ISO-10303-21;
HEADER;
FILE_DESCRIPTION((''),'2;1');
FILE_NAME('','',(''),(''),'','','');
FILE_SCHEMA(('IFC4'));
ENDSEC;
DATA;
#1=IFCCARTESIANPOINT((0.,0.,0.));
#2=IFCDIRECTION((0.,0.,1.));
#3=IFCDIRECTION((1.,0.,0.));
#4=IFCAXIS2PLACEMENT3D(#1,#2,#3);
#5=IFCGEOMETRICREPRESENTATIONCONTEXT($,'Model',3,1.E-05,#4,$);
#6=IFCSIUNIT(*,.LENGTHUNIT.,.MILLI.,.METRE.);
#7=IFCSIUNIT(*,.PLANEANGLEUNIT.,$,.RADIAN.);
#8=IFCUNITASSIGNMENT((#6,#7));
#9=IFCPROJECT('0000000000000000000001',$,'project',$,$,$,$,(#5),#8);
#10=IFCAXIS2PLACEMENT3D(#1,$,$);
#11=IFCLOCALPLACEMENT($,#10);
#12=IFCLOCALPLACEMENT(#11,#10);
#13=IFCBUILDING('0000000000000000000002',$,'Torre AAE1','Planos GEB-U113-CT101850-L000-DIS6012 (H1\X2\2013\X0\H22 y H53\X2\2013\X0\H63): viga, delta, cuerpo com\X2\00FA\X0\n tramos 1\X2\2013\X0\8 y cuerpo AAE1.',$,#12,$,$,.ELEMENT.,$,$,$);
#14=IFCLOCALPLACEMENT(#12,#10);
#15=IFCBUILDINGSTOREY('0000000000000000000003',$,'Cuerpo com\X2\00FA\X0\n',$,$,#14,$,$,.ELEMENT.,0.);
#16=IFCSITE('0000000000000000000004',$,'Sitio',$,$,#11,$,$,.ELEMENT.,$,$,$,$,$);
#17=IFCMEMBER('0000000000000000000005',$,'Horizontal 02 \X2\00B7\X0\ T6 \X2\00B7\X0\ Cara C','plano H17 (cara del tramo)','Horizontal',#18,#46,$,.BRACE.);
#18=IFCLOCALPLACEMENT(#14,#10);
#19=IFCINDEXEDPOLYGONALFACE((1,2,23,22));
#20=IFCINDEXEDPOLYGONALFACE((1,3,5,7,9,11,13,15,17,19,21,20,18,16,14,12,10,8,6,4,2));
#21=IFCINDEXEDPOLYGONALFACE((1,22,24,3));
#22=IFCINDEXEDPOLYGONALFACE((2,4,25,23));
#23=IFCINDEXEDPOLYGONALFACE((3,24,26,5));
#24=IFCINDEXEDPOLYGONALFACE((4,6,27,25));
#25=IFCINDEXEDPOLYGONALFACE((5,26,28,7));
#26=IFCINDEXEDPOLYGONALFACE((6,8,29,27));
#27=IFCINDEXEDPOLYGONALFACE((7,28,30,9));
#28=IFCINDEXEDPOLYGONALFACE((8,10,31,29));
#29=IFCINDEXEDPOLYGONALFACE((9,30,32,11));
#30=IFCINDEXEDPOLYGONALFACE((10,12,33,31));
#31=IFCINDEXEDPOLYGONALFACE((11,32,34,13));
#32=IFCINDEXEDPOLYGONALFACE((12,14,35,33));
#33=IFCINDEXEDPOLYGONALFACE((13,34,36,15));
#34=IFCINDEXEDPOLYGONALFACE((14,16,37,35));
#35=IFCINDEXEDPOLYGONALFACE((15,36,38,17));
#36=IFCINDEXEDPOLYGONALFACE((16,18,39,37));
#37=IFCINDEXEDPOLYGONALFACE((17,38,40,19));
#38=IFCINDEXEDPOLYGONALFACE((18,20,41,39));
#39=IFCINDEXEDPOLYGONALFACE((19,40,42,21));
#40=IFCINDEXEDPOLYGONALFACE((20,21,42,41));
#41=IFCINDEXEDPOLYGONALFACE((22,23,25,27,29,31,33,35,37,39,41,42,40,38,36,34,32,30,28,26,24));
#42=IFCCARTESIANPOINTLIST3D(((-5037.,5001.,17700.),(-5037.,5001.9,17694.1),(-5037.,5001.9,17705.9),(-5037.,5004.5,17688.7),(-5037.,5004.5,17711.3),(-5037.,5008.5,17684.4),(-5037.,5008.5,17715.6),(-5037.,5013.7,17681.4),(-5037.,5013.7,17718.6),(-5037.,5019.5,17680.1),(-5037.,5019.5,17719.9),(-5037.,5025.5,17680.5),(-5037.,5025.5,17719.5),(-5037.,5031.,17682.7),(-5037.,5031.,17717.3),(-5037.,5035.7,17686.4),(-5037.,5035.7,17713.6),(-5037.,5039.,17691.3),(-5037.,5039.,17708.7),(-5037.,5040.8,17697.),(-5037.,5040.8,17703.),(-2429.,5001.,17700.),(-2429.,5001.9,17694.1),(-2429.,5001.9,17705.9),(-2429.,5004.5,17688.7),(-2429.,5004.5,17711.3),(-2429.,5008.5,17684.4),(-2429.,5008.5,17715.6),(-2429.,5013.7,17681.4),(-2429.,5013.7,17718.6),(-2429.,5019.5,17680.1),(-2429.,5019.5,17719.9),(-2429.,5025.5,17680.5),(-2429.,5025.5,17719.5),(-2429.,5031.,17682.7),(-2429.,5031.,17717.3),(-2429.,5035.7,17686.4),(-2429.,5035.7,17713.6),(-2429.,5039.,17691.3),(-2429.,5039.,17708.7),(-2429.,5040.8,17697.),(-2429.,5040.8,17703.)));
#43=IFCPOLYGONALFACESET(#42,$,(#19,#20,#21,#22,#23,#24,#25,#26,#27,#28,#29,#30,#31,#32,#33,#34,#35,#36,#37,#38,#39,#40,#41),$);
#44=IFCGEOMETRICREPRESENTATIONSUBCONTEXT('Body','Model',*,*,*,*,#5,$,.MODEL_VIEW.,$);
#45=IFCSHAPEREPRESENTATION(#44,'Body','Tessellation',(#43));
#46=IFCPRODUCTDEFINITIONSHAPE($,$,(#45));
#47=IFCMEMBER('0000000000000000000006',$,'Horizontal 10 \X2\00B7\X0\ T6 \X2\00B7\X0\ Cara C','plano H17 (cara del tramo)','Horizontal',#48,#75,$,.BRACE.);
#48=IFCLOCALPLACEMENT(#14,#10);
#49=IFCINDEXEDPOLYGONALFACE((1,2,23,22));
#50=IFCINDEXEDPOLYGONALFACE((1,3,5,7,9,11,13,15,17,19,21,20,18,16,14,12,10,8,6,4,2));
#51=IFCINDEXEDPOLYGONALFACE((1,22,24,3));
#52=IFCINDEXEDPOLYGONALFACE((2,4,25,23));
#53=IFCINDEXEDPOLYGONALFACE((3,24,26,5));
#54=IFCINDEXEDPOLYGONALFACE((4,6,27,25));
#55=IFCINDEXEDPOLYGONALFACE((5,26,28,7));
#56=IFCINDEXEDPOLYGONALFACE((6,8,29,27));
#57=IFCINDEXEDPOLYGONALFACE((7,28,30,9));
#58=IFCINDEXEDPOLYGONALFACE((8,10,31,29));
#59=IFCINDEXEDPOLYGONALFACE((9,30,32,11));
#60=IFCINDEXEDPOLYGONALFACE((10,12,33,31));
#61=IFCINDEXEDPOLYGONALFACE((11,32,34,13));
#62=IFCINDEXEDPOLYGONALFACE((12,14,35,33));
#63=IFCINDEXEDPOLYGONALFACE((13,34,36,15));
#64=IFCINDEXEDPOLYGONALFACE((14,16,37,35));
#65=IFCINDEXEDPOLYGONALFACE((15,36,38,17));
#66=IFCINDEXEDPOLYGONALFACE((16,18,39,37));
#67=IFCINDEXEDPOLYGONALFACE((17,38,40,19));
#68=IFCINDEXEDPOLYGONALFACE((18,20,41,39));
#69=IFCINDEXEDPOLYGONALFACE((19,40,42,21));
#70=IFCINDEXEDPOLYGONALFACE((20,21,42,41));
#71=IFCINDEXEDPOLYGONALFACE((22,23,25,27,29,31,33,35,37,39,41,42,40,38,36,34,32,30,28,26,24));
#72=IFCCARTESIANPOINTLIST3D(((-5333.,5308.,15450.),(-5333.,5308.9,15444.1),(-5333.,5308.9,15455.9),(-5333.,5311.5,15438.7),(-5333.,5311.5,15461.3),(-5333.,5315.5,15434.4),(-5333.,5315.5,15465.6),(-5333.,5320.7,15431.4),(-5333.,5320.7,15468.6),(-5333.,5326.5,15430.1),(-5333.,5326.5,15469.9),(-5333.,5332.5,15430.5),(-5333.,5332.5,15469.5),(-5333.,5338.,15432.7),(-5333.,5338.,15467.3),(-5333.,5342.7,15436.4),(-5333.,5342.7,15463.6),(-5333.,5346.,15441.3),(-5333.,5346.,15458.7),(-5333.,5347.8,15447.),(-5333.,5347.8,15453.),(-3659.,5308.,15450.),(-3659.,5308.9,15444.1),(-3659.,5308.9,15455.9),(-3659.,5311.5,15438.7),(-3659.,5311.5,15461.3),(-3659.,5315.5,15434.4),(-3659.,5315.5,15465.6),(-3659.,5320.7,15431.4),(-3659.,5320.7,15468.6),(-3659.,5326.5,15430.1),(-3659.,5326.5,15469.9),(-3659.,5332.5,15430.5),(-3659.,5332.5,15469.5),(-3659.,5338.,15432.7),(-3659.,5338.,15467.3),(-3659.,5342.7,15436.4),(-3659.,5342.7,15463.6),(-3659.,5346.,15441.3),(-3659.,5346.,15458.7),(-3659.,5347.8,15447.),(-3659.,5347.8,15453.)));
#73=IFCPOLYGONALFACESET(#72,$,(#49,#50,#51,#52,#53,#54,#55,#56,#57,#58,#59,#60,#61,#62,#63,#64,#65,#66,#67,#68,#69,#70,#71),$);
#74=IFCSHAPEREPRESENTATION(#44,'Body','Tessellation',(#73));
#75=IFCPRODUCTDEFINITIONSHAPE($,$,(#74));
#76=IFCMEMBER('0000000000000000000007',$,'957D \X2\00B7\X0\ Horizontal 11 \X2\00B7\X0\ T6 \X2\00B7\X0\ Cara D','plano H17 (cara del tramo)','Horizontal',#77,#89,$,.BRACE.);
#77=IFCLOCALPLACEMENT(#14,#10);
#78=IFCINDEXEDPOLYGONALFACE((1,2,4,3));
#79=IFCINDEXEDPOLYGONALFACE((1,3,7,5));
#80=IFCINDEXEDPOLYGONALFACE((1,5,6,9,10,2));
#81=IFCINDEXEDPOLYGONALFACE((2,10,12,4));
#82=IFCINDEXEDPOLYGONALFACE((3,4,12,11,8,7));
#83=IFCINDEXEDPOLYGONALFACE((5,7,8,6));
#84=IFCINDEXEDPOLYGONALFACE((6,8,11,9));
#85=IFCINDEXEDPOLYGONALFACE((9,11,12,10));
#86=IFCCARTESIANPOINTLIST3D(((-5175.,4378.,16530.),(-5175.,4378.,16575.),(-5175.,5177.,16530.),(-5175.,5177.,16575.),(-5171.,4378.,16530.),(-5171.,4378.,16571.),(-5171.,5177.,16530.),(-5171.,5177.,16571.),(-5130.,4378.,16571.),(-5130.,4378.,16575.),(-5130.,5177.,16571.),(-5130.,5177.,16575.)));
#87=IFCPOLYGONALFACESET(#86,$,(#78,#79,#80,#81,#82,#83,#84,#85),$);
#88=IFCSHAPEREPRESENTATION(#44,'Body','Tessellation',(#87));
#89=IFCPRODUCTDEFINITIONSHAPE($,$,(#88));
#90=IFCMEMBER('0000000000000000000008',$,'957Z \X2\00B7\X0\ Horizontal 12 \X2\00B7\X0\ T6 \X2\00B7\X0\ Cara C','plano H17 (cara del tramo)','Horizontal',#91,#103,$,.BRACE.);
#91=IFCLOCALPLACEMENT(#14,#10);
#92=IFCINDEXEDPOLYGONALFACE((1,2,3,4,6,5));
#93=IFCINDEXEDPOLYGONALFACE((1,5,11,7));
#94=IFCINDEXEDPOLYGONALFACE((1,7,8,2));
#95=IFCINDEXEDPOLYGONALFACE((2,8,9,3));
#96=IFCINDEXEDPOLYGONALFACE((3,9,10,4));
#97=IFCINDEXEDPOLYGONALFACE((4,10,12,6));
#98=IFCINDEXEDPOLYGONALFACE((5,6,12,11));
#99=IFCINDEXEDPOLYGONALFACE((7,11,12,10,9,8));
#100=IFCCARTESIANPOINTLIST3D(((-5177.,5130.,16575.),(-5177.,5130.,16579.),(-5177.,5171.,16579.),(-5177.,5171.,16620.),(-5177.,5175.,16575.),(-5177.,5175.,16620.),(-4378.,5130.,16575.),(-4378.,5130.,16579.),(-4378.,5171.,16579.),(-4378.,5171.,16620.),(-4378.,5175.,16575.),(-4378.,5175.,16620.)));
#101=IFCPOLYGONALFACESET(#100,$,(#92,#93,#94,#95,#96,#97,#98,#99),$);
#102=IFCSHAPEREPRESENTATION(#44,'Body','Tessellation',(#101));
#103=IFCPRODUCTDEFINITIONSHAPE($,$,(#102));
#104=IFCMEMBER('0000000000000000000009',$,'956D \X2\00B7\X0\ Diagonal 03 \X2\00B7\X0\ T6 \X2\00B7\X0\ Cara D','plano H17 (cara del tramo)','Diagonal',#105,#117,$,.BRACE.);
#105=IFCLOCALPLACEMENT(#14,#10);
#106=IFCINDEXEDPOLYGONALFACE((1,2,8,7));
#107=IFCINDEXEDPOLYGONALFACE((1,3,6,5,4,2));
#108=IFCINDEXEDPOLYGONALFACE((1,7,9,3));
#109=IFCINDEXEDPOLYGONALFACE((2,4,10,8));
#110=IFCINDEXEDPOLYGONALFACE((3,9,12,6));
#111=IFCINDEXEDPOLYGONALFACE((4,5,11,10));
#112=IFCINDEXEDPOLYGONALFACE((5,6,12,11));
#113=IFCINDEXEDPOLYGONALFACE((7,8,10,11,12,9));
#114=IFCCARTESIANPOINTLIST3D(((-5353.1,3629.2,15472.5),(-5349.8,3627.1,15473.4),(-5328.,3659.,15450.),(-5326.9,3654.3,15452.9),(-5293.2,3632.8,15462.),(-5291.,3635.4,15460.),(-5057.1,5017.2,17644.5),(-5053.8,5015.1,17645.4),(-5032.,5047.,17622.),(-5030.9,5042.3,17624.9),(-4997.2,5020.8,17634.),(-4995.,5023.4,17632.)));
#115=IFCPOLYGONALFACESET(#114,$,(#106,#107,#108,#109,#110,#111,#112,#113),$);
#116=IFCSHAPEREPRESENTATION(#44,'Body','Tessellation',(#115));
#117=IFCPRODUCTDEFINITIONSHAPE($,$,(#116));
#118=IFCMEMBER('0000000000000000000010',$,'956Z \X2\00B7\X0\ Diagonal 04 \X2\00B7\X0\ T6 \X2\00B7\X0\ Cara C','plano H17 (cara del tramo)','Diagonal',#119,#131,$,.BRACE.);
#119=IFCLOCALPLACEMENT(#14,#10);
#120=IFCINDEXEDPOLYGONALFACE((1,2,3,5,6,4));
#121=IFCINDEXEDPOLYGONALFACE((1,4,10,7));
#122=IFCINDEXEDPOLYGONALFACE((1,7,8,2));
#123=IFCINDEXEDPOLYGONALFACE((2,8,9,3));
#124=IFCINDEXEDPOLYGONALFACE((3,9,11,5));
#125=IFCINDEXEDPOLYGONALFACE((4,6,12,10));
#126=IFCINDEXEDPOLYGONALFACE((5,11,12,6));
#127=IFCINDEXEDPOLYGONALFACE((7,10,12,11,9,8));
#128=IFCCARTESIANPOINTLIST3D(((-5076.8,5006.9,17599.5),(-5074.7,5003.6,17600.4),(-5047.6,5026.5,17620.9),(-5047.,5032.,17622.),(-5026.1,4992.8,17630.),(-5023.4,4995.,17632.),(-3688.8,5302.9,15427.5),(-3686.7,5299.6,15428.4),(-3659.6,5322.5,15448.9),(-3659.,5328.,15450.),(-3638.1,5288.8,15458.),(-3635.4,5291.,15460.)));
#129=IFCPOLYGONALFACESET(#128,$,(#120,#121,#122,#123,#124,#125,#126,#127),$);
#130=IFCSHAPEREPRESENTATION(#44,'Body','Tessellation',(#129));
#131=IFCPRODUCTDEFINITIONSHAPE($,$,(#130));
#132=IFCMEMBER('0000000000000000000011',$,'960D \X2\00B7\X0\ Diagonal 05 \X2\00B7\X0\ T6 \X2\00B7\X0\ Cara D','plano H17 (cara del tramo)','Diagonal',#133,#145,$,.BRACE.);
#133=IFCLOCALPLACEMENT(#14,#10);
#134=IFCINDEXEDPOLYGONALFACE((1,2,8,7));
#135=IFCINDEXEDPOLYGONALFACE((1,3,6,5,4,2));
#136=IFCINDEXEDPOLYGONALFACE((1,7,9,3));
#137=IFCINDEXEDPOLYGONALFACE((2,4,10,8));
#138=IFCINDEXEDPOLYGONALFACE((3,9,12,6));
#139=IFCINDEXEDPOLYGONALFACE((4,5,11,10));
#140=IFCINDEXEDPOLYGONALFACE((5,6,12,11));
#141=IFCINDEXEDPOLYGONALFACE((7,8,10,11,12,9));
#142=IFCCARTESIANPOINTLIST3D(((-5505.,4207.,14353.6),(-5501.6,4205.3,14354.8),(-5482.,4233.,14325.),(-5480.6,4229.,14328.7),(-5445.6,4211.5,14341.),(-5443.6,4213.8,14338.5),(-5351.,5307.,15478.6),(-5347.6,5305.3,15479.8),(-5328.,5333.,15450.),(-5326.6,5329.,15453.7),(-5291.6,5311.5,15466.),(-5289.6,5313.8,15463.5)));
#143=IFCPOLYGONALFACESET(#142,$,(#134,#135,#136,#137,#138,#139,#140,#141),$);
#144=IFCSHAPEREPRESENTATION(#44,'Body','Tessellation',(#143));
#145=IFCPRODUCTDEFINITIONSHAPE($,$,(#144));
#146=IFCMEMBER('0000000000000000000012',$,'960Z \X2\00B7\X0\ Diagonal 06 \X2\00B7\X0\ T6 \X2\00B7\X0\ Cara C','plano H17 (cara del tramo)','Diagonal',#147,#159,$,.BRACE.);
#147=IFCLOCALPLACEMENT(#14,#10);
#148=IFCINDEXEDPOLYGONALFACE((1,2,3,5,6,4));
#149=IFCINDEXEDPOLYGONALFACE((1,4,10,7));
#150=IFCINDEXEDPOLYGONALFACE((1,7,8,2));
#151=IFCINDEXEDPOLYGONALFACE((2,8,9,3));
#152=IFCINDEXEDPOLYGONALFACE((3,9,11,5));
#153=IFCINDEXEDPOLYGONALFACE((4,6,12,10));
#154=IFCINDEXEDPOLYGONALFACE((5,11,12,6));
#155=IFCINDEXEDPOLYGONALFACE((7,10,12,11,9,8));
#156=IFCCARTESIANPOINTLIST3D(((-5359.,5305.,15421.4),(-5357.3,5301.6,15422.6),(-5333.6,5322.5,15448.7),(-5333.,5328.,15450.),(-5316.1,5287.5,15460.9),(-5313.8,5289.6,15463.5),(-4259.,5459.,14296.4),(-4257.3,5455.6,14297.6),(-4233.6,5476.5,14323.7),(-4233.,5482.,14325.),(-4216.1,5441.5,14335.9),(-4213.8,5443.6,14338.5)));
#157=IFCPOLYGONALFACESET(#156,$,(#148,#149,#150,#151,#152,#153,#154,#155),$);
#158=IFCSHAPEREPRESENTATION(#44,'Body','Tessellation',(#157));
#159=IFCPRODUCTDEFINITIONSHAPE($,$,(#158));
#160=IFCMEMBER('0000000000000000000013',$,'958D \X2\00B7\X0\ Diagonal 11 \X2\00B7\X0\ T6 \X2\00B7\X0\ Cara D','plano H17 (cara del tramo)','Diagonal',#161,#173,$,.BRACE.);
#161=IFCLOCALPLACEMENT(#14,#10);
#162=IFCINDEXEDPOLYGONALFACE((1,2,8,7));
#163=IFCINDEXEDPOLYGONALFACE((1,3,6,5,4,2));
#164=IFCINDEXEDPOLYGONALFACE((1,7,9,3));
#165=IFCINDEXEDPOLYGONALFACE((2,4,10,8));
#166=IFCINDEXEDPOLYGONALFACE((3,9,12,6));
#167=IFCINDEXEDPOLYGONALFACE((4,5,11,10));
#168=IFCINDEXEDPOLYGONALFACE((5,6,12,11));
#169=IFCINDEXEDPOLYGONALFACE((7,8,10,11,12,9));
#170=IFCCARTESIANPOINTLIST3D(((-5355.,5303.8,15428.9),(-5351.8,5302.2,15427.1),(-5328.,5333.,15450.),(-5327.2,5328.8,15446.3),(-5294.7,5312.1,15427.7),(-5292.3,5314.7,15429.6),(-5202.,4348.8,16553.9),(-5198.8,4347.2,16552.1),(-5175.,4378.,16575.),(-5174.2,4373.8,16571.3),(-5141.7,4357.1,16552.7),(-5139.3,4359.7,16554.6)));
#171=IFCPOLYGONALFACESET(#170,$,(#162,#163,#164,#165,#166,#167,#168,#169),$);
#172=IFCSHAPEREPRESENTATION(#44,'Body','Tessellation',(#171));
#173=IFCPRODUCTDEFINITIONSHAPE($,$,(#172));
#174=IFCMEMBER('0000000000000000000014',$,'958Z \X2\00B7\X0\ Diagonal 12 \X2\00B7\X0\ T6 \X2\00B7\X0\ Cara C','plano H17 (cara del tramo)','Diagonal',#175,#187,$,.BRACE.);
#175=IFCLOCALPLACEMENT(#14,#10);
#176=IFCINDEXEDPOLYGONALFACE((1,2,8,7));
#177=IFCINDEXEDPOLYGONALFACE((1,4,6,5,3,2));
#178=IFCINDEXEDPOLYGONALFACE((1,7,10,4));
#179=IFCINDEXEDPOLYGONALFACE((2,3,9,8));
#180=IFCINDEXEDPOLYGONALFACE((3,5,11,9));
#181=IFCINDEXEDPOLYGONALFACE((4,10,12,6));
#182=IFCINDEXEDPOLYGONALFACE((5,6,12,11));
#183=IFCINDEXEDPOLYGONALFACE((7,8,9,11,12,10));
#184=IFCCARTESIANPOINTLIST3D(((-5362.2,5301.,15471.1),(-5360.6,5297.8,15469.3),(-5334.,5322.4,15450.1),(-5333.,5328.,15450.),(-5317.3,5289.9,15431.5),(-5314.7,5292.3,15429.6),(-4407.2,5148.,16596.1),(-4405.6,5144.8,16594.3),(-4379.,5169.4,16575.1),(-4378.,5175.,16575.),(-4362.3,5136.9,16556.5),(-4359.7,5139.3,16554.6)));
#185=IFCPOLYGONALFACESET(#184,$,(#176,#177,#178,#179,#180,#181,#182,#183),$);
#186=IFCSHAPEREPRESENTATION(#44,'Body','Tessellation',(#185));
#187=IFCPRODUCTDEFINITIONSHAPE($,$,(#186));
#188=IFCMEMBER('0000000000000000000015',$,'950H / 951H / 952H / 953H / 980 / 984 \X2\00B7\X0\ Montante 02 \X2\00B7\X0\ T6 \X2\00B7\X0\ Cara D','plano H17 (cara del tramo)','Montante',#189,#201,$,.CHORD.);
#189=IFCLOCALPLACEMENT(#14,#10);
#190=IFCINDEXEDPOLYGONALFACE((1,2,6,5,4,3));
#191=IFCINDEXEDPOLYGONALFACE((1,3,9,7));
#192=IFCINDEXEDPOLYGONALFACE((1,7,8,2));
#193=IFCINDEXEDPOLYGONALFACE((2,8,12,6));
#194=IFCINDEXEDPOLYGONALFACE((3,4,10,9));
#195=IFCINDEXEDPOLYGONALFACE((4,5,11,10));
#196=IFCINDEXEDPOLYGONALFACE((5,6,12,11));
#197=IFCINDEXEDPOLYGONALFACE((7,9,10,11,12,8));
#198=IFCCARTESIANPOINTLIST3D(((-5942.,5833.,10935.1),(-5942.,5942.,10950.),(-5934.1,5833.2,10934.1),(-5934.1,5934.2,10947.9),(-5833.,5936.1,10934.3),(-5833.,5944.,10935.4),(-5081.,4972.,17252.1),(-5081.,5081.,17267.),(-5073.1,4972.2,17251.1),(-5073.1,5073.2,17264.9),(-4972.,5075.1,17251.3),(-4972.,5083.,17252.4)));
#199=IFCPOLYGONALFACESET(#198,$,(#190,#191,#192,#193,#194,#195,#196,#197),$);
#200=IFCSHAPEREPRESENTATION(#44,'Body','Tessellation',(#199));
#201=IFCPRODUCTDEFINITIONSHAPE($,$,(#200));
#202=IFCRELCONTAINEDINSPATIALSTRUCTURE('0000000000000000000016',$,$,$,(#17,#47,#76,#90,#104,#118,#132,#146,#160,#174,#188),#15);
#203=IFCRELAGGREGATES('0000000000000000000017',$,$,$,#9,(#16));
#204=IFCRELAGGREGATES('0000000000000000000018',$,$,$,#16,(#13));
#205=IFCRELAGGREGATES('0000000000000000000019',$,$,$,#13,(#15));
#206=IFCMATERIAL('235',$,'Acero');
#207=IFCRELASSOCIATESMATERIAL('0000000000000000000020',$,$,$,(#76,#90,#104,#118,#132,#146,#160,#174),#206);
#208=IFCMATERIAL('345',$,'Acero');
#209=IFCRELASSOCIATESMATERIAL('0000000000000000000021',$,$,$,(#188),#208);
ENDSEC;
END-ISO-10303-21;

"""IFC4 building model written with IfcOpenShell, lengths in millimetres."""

from ifc_helpers import new_model, si_unit, frame, frame_2d, origin, origin_with_axes, place, context, subcontext, project, spatial, circle, l_section, extrude, material, element, save


model = new_model("IFC4")

# Units and contexts
model_context = context("Model", 3, precision=1e-05, world=origin_with_axes())
body_context = subcontext(model_context, "Body", "Model", "MODEL_VIEW")
ifc_project = project(units=[si_unit("LENGTHUNIT", "METRE", prefix="MILLI"), si_unit("PLANEANGLEUNIT", "RADIAN")], contexts=[model_context])

# Site, building, storey
site_placement = place(None, origin())
site = spatial("IfcSite", under=ifc_project, at=site_placement, Name="Sitio", CompositionType="ELEMENT")
building_placement = place(site_placement, origin())
building = spatial("IfcBuilding", under=site, at=building_placement, Name="Torre AAE1", Description="Planos GEB-U113-CT101850-L000-DIS6012 (H1–H22 y H53–H63): viga, delta, cuerpo común tramos 1–8 y cuerpo AAE1.", CompositionType="ELEMENT")
storey_placement = place(building_placement, origin())
storey = spatial("IfcBuildingStorey", under=building, at=storey_placement, Name="Cuerpo común", CompositionType="ELEMENT", Elevation=0.0)

# Members
for number, where, z_axis, x_axis, name in (
    (1, (-5037.0, 5021.0, 17700.0), (1.0, 0.0, 0.0), (0.0, -1.0, 0.0), "Horizontal 02 · T6 · Cara C"),
):
    element("IfcMember", number, at=place(storey_placement, frame(where, z_axis=z_axis, x_axis=x_axis)), inside=storey, Name=name, Description="plano H17 (cara del tramo)", ObjectType="Horizontal", PredefinedType="BRACE", context=body_context, shape_type="SweptSolid", body=[
        extrude(circle(Radius=20.0), None, (0.0, 0.0, 1.0), 2608.0),
    ])
member_1_placement = place(storey_placement, frame((-3659.0, 5328.0, 15450.0), z_axis=(-1.0, 0.0, 0.0), x_axis=(0.0, -1.0, 0.0)))
element("IfcMember", 2, at=member_1_placement, inside=storey, Name="Horizontal 10 · T6 · Cara C", Description="plano H17 (cara del tramo)", ObjectType="Horizontal", PredefinedType="BRACE", context=body_context, shape_type="SweptSolid", body=[
    extrude(circle(Radius=20.0), None, (0.0, 0.0, 1.0), 1674.0),
])
ifc_material_1 = material(Name="235", Category="Acero")
for number, where, z_axis, x_axis, name in (
    (3, (-5175.0, 4378.0, 16575.0), (0.0, 1.0, 0.0), (1.0, 0.0, 0.0), "957D · Horizontal 11 · T6 · Cara D"),
    (4, (-4378.0, 5175.0, 16575.0), (-1.0, 0.0, 0.0), (0.0, -1.0, 0.0), "957Z · Horizontal 12 · T6 · Cara C"),
):
    element("IfcMember", number, at=place(storey_placement, frame(where, z_axis=z_axis, x_axis=x_axis)), inside=storey, material=ifc_material_1, Name=name, Description="plano H17 (cara del tramo)", ObjectType="Horizontal", PredefinedType="BRACE", context=body_context, shape_type="SweptSolid", body=[
        extrude(l_section(Depth=45.0, Width=45.0, Thickness=4.0, at=frame_2d((22.5, 22.5))), None, (0.0, 0.0, 1.0), 799.0),
    ])
for number, where, z_axis, x_axis, name in (
    (5, (-5032.0, 5047.0, 17622.0), (-0.114085, -0.534965, -0.837136), (0.822462, -0.523514, 0.222463), "956D · Diagonal 03 · T6 · Cara D"),
    (6, (-5047.0, 5032.0, 17622.0), (0.534965, 0.114085, -0.837136), (0.523514, -0.822462, 0.222463), "956Z · Diagonal 04 · T6 · Cara C"),
):
    element("IfcMember", number, at=place(storey_placement, frame(where, z_axis=z_axis, x_axis=x_axis)), inside=storey, material=ifc_material_1, Name=name, Description="plano H17 (cara del tramo)", ObjectType="Diagonal", PredefinedType="BRACE", context=body_context, shape_type="SweptSolid", body=[
        extrude(l_section(Depth=45.0, Width=45.0, Thickness=4.0, at=frame_2d((22.5, 22.5))), None, (0.0, 0.0, 1.0), 2594.6),
    ])
for number, where, z_axis, x_axis, name in (
    (7, (-5328.0, 5333.0, 15450.0), (-0.097411, -0.695793, -0.711606), (0.853622, -0.426031, 0.299712), "960D · Diagonal 05 · T6 · Cara D"),
    (8, (-5333.0, 5328.0, 15450.0), (0.695793, 0.097411, -0.711606), (0.426031, -0.853622, 0.299712), "960Z · Diagonal 06 · T6 · Cara C"),
):
    element("IfcMember", number, at=place(storey_placement, frame(where, z_axis=z_axis, x_axis=x_axis)), inside=storey, material=ifc_material_1, Name=name, Description="plano H17 (cara del tramo)", ObjectType="Diagonal", PredefinedType="BRACE", context=body_context, shape_type="SweptSolid", body=[
        extrude(l_section(Depth=45.0, Width=45.0, Thickness=4.0, at=frame_2d((22.5, 22.5))), None, (0.0, 0.0, 1.0), 1580.9),
    ])
for number, where, z_axis, x_axis, name in (
    (9, (-5175.0, 4378.0, 16575.0), (-0.103128, 0.643706, -0.758292), (0.793627, -0.40631, -0.452845), "958D · Diagonal 11 · T6 · Cara D"),
    (10, (-4378.0, 5175.0, 16575.0), (-0.643706, 0.103128, -0.758292), (0.40631, -0.793627, -0.452845), "958Z · Diagonal 12 · T6 · Cara C"),
):
    element("IfcMember", number, at=place(storey_placement, frame(where, z_axis=z_axis, x_axis=x_axis)), inside=storey, material=ifc_material_1, Name=name, Description="plano H17 (cara del tramo)", ObjectType="Diagonal", PredefinedType="BRACE", context=body_context, shape_type="SweptSolid", body=[
        extrude(l_section(Depth=45.0, Width=45.0, Thickness=4.0, at=frame_2d((22.5, 22.5))), None, (0.0, 0.0, 1.0), 1483.6),
    ])
ifc_material_2 = material(Name="345", Category="Acero")
member_2_placement = place(storey_placement, frame((-5081.0, 5081.0, 17267.0), z_axis=(-0.133835, 0.133835, -0.981925), x_axis=(0.991004, 0.018074, -0.132609)))
element("IfcMember", 11, at=member_2_placement, inside=storey, material=ifc_material_2, Name="950H / 951H / 952H / 953H / 980 / 984 · Montante 02 · T6 · Cara D", Description="plano H17 (cara del tramo)", ObjectType="Montante", PredefinedType="CHORD", context=body_context, shape_type="SweptSolid", body=[
    extrude(l_section(Depth=110.0, Width=110.0, Thickness=8.0, at=frame_2d((55.0, 55.0))), None, (0.0, 0.0, 1.0), 6433.3),
])

save(model, "model.ifc")
